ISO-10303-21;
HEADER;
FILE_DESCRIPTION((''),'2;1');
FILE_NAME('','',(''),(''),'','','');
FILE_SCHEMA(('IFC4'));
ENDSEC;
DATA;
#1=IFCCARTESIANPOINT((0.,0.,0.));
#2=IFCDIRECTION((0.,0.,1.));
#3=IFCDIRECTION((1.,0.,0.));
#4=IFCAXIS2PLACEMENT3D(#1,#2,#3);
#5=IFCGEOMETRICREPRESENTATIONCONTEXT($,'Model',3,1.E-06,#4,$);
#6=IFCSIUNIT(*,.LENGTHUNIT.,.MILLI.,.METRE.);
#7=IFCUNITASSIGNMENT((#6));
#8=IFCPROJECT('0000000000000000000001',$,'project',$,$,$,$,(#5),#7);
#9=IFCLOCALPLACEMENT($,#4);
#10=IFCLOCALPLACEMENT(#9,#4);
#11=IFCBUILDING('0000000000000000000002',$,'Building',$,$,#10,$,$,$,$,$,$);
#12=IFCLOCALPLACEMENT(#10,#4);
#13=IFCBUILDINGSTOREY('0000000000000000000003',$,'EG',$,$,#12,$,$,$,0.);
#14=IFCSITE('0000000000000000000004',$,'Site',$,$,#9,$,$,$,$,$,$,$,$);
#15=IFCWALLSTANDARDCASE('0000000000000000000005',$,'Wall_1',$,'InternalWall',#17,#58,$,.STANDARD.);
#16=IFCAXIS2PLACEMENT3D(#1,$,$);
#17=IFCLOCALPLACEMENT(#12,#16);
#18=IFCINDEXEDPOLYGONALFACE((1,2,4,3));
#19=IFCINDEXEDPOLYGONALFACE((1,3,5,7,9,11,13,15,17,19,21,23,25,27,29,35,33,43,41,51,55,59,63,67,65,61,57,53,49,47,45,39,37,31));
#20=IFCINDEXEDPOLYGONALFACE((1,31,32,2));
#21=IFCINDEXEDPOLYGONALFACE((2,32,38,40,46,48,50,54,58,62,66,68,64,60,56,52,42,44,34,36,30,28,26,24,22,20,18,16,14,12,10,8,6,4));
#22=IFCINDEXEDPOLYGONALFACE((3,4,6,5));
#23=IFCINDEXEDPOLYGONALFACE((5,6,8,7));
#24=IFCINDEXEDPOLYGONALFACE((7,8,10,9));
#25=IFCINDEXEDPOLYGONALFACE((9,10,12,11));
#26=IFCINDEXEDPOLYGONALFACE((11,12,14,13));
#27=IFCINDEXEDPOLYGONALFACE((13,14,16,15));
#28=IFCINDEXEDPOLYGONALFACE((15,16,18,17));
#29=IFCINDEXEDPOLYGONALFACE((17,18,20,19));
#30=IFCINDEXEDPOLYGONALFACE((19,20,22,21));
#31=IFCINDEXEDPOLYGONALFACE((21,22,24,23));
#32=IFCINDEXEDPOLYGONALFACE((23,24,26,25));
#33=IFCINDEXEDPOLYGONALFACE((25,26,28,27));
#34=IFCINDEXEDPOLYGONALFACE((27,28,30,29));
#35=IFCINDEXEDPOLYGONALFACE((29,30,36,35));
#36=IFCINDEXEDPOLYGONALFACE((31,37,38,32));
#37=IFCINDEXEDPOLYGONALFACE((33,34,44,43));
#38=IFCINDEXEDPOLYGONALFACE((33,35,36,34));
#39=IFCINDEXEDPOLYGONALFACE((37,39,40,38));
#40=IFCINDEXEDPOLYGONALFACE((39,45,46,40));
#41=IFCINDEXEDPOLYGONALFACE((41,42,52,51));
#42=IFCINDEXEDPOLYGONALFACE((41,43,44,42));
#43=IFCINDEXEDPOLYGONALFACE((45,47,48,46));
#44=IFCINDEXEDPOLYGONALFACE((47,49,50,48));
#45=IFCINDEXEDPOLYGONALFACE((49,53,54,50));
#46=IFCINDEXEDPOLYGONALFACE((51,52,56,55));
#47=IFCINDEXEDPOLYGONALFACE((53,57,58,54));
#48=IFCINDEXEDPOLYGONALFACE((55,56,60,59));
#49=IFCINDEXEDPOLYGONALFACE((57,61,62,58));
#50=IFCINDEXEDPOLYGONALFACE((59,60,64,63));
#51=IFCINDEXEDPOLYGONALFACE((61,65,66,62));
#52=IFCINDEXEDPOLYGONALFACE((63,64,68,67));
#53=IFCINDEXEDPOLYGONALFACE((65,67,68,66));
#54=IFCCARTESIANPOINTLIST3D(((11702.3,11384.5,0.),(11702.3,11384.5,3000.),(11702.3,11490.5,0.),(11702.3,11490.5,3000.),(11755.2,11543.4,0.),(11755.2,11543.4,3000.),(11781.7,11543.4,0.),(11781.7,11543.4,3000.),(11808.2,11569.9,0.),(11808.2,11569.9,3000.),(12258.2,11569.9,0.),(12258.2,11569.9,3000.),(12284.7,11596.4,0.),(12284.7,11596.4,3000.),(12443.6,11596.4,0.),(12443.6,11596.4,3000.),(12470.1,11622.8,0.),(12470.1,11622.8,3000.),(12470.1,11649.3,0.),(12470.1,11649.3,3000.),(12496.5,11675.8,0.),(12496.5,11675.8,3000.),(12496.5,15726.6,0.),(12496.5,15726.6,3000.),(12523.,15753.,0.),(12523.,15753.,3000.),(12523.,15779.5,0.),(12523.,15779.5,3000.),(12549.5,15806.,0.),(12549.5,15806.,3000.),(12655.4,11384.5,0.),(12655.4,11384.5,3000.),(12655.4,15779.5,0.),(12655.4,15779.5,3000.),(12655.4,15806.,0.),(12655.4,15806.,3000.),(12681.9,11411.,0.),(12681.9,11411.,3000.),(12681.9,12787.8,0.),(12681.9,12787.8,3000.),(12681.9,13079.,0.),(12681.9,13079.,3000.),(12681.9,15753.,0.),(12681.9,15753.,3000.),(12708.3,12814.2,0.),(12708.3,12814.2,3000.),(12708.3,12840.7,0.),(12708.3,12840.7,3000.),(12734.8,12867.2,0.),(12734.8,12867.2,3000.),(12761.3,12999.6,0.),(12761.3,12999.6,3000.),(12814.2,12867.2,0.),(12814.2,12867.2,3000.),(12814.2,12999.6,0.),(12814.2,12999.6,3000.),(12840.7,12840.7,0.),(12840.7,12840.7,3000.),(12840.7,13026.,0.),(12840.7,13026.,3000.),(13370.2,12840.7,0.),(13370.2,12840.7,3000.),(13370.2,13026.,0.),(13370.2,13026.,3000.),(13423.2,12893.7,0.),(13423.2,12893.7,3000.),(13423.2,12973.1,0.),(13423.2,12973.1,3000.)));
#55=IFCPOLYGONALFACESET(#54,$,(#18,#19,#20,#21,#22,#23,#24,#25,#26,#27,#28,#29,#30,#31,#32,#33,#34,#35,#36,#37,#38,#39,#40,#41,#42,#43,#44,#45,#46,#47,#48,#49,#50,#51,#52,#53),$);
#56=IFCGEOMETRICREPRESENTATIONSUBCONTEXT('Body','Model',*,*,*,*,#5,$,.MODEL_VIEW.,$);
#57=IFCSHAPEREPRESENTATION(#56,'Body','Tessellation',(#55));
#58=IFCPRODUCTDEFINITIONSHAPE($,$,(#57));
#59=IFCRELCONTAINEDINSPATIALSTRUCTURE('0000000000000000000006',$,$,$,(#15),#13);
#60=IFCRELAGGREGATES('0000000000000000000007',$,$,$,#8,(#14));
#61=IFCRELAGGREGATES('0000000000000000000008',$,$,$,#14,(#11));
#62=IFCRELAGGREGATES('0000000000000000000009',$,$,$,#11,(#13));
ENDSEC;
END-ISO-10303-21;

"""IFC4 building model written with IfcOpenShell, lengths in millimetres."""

from ifc_helpers import new_model, si_unit, frame, origin_with_axes, place, context, subcontext, project, spatial, polyline, outline, extrude, element, save


model = new_model("IFC4")

# Units and contexts
model_context = context("Model", 3, precision=1e-06, world=origin_with_axes())
body_context = subcontext(model_context, "Body", "Model", "MODEL_VIEW")
ifc_project = project(units=[si_unit("LENGTHUNIT", "METRE", prefix="MILLI")], contexts=[model_context])

# Site, building, storey
site_placement = place(None, origin_with_axes())
site = spatial("IfcSite", under=ifc_project, at=site_placement, Name="Site")
building_placement = place(site_placement, origin_with_axes())
building = spatial("IfcBuilding", under=site, at=building_placement, Name="Building")
storey_placement = place(building_placement, origin_with_axes())
storey = spatial("IfcBuildingStorey", under=building, at=storey_placement, Name="EG", Elevation=0.0)

# Wall
for number, where, z_axis, x_axis, name in (
    (1, (0.0, 0.0, 0.0), (0.0, 0.0, 1.0), (1.0, 0.0, 0.0), "Wall_1"),
):
    element("IfcWallStandardCase", number, at=place(storey_placement, frame(where, z_axis=z_axis, x_axis=x_axis)), inside=storey, Name=name, ObjectType="InternalWall", PredefinedType="STANDARD", context=body_context, shape_type="SweptSolid", body=[
        extrude(outline(polyline([(11702.3, 11384.5, 0.0), (11702.3, 11490.5, 0.0), (11755.2, 11543.4, 0.0), (11781.7, 11543.4, 0.0), (11808.2, 11569.9, 0.0), (12258.2, 11569.9, 0.0), (12284.7, 11596.4, 0.0), (12443.6, 11596.4, 0.0), (12470.1, 11622.8, 0.0), (12470.1, 11649.3, 0.0), (12496.5, 11675.8, 0.0), (12496.5, 15726.6, 0.0), (12523.0, 15753.0, 0.0), (12523.0, 15779.5, 0.0), (12549.5, 15806.0, 0.0), (12655.4, 15806.0, 0.0), (12655.4, 15779.5, 0.0), (12681.9, 15753.0, 0.0), (12681.9, 13079.0, 0.0), (12761.3, 12999.6, 0.0), (12814.2, 12999.6, 0.0), (12840.7, 13026.0, 0.0), (13370.2, 13026.0, 0.0), (13423.2, 12973.1, 0.0), (13423.2, 12893.7, 0.0), (13370.2, 12840.7, 0.0), (12840.7, 12840.7, 0.0), (12814.2, 12867.2, 0.0), (12734.8, 12867.2, 0.0), (12708.3, 12840.7, 0.0), (12708.3, 12814.2, 0.0), (12681.9, 12787.8, 0.0), (12681.9, 11411.0, 0.0), (12655.4, 11384.5, 0.0), (11702.3, 11384.5, 0.0)])), origin_with_axes(), (0.0, 0.0, 1.0), 3000.0),
    ])

save(model, "model.ifc")
